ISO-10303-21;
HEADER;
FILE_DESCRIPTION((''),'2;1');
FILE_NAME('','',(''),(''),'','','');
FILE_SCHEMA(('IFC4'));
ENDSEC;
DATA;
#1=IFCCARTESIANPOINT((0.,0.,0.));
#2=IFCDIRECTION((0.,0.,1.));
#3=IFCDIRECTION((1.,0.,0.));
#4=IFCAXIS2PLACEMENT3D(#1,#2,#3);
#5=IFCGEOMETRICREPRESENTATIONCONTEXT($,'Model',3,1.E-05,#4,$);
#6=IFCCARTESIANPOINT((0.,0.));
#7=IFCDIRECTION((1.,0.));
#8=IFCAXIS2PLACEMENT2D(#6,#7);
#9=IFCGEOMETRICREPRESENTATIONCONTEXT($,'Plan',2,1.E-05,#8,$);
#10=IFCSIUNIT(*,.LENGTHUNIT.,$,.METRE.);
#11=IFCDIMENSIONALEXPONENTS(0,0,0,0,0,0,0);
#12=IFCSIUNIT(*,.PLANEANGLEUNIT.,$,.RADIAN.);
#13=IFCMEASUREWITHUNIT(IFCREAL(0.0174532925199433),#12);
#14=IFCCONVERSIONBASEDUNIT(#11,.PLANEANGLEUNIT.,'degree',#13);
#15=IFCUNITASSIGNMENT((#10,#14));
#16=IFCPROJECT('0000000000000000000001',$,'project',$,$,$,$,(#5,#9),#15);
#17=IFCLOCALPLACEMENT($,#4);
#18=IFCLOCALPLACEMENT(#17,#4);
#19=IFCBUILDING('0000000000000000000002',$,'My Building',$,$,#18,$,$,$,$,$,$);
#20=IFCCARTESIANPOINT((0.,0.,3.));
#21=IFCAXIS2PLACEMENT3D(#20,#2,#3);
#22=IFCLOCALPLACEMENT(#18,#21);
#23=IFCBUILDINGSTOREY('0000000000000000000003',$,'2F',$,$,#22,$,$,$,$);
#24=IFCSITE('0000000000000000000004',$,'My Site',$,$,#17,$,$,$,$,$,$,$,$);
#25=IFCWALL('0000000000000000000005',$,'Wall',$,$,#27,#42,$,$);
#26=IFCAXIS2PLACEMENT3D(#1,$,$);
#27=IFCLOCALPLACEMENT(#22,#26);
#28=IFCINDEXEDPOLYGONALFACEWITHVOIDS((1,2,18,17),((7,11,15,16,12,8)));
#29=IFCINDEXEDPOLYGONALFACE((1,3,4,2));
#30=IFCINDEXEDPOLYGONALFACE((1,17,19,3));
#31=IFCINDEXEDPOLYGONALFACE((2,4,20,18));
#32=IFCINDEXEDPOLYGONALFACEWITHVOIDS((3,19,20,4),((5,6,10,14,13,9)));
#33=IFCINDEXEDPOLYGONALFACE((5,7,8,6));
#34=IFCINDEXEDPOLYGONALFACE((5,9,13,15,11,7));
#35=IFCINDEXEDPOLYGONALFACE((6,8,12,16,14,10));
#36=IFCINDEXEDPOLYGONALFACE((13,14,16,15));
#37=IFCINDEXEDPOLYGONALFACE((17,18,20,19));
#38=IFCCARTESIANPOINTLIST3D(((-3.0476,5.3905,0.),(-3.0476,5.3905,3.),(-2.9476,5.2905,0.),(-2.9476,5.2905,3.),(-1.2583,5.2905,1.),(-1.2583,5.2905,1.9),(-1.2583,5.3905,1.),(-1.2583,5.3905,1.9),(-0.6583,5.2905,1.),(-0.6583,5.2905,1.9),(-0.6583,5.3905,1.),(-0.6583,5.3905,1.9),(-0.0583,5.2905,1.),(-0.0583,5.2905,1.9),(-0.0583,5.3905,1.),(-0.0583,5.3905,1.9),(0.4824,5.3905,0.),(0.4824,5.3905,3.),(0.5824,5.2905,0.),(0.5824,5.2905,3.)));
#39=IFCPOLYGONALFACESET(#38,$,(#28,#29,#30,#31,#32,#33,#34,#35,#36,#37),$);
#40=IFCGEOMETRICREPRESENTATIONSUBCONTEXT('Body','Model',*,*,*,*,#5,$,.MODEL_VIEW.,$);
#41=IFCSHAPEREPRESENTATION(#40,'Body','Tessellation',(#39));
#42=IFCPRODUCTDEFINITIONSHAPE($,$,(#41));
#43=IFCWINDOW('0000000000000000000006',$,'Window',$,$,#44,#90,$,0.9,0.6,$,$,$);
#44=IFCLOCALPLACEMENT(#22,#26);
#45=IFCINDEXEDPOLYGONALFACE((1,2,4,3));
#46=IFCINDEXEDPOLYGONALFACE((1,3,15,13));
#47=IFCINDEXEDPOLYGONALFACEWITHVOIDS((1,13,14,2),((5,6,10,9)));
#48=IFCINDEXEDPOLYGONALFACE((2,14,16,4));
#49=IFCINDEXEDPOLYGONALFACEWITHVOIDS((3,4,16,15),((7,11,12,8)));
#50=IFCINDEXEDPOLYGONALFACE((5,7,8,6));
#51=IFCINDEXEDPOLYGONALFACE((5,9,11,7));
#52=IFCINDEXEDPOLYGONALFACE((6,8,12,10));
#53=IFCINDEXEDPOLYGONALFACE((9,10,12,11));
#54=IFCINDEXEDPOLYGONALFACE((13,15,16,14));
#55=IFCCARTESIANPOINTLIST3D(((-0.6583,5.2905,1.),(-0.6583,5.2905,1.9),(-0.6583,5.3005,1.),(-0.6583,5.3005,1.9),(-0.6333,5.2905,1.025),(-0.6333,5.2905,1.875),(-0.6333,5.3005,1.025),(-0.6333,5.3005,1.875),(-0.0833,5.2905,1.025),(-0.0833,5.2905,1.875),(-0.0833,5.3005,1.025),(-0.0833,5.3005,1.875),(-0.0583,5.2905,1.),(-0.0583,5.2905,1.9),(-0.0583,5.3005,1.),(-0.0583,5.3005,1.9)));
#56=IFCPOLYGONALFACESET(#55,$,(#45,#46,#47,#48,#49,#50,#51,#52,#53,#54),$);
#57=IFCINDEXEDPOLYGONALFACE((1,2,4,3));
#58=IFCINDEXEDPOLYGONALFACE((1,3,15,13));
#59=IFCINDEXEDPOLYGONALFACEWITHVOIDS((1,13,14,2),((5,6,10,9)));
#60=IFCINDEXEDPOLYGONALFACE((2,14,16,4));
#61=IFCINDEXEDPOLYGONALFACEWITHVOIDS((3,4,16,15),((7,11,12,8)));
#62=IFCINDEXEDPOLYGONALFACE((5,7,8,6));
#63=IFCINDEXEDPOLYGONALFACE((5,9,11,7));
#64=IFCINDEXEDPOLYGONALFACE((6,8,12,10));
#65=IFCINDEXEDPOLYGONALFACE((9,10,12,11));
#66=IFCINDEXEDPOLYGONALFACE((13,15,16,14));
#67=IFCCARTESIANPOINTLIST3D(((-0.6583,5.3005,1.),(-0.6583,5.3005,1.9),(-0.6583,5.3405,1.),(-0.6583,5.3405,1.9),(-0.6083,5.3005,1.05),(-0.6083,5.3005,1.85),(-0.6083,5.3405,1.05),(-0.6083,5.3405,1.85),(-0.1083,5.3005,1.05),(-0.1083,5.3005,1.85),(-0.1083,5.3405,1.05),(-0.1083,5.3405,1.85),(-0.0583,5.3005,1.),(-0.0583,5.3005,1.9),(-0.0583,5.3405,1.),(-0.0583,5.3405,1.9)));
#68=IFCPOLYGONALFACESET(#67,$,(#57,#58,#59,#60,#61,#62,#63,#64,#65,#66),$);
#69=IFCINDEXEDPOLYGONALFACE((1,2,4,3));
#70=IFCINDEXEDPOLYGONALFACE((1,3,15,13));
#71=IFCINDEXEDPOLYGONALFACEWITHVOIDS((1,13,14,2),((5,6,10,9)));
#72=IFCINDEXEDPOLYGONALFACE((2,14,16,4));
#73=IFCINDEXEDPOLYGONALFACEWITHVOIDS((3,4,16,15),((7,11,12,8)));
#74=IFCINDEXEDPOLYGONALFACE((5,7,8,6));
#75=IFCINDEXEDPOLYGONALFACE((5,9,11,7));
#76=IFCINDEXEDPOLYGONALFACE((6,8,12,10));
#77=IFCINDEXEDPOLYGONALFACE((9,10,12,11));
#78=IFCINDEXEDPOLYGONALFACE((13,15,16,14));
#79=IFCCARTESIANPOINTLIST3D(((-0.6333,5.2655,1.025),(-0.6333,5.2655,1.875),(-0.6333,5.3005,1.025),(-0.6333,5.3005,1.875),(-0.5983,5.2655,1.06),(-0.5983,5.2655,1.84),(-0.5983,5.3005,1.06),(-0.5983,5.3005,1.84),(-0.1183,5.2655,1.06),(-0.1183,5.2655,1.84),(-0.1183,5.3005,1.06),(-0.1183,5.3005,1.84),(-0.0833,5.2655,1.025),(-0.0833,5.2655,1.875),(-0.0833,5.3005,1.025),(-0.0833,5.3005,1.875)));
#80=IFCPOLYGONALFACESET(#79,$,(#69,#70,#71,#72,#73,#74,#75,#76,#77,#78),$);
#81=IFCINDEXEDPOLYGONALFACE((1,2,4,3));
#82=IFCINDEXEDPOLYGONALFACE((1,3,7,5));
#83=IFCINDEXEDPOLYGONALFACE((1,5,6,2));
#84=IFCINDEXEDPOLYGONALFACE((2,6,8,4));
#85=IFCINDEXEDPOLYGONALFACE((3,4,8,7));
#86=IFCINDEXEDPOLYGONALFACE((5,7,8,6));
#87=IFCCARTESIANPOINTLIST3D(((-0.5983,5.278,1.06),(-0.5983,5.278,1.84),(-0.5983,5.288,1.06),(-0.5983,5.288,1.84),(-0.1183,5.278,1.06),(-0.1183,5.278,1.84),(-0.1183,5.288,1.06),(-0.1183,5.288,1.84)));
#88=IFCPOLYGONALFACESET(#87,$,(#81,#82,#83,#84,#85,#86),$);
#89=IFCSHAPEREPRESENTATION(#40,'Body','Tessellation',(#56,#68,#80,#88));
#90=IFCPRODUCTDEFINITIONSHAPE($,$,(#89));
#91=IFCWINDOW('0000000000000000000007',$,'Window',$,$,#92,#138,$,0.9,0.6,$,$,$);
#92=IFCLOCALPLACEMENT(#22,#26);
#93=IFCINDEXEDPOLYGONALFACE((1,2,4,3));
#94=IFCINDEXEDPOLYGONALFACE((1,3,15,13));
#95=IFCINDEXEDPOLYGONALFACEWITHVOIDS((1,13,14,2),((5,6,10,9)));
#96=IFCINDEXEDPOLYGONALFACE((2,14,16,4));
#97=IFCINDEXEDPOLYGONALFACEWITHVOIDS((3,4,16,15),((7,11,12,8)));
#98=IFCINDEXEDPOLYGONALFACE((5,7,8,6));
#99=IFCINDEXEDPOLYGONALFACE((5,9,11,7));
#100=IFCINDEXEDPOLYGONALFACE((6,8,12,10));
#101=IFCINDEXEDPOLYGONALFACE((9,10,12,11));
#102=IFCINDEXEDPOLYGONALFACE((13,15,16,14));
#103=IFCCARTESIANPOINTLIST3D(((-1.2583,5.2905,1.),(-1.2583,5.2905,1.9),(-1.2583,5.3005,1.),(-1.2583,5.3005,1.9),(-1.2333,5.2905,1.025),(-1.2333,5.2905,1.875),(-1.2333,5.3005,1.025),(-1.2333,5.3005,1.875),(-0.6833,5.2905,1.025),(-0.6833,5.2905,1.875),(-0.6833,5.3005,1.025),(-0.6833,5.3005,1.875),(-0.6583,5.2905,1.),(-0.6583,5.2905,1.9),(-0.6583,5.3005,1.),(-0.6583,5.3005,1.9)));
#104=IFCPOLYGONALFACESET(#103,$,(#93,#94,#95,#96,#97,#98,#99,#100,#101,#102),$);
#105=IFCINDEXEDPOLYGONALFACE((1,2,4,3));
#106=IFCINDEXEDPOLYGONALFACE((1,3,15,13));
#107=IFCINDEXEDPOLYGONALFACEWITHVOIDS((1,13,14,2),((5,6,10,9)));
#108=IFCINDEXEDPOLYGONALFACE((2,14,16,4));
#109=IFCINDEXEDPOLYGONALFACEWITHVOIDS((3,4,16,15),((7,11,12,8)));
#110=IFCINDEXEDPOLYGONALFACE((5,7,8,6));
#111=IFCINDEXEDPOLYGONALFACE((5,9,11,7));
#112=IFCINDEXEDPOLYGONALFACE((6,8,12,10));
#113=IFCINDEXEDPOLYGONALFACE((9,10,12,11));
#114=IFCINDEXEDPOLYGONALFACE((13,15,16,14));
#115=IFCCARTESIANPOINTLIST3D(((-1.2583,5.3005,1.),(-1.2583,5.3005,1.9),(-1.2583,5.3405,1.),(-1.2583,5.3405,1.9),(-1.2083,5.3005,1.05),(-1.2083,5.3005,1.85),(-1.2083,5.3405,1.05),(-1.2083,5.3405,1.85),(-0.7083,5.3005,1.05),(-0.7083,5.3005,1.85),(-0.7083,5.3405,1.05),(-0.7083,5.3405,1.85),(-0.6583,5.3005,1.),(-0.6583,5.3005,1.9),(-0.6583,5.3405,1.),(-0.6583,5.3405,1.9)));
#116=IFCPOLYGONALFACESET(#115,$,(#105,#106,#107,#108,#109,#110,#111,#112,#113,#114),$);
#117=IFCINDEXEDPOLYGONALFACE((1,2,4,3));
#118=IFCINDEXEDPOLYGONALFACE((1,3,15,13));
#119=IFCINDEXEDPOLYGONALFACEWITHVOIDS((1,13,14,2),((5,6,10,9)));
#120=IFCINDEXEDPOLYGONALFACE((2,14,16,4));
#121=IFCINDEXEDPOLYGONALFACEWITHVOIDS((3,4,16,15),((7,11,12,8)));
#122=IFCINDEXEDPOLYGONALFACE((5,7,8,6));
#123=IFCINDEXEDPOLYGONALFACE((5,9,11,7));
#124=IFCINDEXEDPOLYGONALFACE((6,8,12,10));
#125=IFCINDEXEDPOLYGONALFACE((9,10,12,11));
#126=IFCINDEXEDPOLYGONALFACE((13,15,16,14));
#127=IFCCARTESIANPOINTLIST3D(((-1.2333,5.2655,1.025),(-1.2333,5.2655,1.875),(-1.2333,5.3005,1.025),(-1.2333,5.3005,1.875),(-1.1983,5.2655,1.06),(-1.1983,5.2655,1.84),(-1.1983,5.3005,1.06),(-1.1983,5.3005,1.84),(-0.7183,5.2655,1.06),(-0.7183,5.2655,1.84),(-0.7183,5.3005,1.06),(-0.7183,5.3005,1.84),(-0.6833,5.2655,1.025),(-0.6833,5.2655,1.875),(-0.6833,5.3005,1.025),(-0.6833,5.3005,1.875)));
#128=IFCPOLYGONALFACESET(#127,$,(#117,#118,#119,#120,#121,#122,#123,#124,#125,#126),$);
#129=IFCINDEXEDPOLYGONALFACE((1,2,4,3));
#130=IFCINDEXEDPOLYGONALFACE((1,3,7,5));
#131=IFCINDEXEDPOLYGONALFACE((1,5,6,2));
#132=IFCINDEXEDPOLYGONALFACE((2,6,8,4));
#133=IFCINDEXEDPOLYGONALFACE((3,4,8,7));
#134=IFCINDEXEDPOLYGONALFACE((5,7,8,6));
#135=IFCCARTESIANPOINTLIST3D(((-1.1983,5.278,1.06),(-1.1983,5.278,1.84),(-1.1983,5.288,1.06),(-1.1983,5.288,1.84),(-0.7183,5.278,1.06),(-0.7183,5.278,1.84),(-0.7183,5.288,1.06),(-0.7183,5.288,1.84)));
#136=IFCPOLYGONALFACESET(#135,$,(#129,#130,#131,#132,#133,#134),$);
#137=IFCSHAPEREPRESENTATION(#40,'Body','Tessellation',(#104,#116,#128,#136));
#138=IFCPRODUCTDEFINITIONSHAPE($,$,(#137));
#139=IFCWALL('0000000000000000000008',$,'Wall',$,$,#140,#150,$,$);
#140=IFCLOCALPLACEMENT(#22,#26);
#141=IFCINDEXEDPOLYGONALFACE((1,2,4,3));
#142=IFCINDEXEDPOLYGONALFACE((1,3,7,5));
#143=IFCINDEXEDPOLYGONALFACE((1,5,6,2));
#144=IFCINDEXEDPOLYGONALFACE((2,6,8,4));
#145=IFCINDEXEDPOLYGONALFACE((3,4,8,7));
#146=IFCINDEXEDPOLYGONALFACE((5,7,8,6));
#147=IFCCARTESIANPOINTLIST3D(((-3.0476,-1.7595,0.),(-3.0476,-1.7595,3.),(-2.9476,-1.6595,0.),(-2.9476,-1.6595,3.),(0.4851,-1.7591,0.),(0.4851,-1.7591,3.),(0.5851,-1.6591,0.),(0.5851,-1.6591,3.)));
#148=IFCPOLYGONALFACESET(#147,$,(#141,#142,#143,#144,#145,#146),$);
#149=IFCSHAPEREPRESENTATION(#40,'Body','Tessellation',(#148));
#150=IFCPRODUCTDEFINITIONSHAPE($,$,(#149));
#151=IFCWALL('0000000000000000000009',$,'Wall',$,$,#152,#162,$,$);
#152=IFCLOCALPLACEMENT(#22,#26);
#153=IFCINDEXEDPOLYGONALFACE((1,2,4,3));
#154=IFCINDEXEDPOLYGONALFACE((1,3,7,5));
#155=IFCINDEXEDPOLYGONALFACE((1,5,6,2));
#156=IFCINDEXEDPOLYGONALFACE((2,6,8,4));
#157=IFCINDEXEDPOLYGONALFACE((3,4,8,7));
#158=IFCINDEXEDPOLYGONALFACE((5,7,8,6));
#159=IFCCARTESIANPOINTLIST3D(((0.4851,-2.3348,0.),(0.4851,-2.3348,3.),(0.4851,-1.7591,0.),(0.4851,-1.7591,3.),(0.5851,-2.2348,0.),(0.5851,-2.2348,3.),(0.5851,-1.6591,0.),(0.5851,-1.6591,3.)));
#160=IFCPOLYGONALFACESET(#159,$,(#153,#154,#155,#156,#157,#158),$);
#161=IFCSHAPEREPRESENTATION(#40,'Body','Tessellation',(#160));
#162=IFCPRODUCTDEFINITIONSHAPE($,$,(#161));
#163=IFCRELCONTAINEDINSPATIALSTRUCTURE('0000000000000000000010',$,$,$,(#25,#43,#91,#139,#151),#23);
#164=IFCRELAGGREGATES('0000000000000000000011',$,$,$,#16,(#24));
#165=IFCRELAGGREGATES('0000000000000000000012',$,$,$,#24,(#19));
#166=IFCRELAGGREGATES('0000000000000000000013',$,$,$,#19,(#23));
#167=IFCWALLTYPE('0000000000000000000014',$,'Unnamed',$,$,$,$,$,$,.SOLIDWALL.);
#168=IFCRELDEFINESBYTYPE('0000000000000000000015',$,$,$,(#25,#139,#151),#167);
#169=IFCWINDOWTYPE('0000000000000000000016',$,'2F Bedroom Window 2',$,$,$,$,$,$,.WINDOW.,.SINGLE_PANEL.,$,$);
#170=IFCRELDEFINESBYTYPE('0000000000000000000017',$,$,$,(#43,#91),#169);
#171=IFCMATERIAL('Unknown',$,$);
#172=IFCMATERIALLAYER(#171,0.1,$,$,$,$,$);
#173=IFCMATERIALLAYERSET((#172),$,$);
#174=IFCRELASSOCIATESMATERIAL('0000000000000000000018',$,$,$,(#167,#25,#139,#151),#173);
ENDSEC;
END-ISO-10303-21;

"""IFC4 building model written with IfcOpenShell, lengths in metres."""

from ifc_helpers import new_model, entity, si_unit, converted_unit, frame, origin_with_axes, origin_2d_with_axis, place, context, subcontext, project, spatial, line, indexed_curve, outline, extrude, shape, source, transform, mapped, material, layer, layer_set, layer_usage, type_object, type_shapes, element, fill, save


model = new_model("IFC4")

# Units and contexts
model_context = context("Model", 3, precision=1e-05, world=origin_with_axes())
plan_context = context("Plan", 2, precision=1e-05, world=origin_2d_with_axis())
body_context_1 = subcontext(model_context, "Body", "Model", "MODEL_VIEW")
body_context_2 = subcontext(plan_context, "Body", "Plan", "PLAN_VIEW")
ifc_project = project(units=[si_unit("LENGTHUNIT", "METRE"), converted_unit("PLANEANGLEUNIT", "degree", entity("IfcReal", 0.0174532925199433), si_unit("PLANEANGLEUNIT", "RADIAN"), dimensions=[0, 0, 0, 0, 0, 0, 0])], contexts=[model_context, plan_context])

# Site, building, storey
site_placement = place(None, origin_with_axes())
site = spatial("IfcSite", under=ifc_project, at=site_placement, Name="My Site")
building_placement = place(site_placement, origin_with_axes())
building = spatial("IfcBuilding", under=site, at=building_placement, Name="My Building")
storey_placement = place(building_placement, frame((0.0, 0.0, 3.0), z_axis=(0.0, 0.0, 1.0), x_axis=(1.0, 0.0, 0.0)))
storey = spatial("IfcBuildingStorey", under=building, at=storey_placement, Name="2F")

# Shared definitions
ifc_material = material(Name="Unknown")

# Shared definitions
ifc_layer_1 = layer(ifc_material, 0.1)
ifc_layer_set_1 = layer_set([ifc_layer_1])
wall_type = type_object("IfcWallType", Name="Unnamed", PredefinedType="SOLIDWALL", material=ifc_layer_set_1)

# Wall, openings, windows
ifc_layer_usage_1 = layer_usage(ifc_layer_set_1, "AXIS2", "POSITIVE", 0.0)
wall_1_placement = place(storey_placement, frame((0.4824, 5.3905, 0.0), z_axis=(0.0, 0.0, 1.0), x_axis=(-1.0, 0.0, 0.0)))
wall_1 = element("IfcWall", 1, at=wall_1_placement, inside=storey, type_object=wall_type, material=ifc_layer_usage_1, Name="Wall", context=body_context_1, shape_type="SweptSolid", body=[
    extrude(outline(indexed_curve([(0.0, 0.0), (-0.1, 0.1), (3.43, 0.1), (3.53, 0.0)], segments=[line(1, 2, 3, 4, 1)])), origin_with_axes(), (0.0, 0.0, 1.0), 3.0),
])
shared_shape_1 = source(origin_with_axes(), body_context_1, "Body", "SweptSolid", [
    extrude(outline(indexed_curve([(0.0, 0.0), (0.6, 0.0), (0.6, 0.9), (0.0, 0.9)], segments=[line(1, 2, 3, 4, 1)])), frame((0.0, -0.6, 0.0), z_axis=(0.0, -1.0, 0.0), x_axis=(1.0, 0.0, 0.0)), (0.0, 0.0, -1.0), 1.2),
])
opening_1_placement = place(wall_1_placement, frame((0.5406, 0.0, 1.0), z_axis=(0.0, 0.0, 1.0), x_axis=(1.0, 0.0, 0.0)))
opening_1 = element("IfcOpeningElement", 2, at=opening_1_placement, cuts=wall_1, PredefinedType="OPENING", context=body_context_1, shape_type="MappedRepresentation", body=[
    mapped(shared_shape_1, transform((0.0, 0.0, 0.0), x_axis=(1.0, 0.0, 0.0), y_axis=(0.0, 1.0, 0.0), z_axis=(0.0, 0.0, 1.0), scale=1.0)),
])
opening_2_placement = place(wall_1_placement, frame((1.1406, 0.0, 1.0), z_axis=(0.0, 0.0, 1.0), x_axis=(1.0, 0.0, 0.0)))
opening_2 = element("IfcOpeningElement", 3, at=opening_2_placement, cuts=wall_1, PredefinedType="OPENING", context=body_context_1, shape_type="MappedRepresentation", body=[
    mapped(shared_shape_1, transform((0.0, 0.0, 0.0), x_axis=(1.0, 0.0, 0.0), y_axis=(0.0, 1.0, 0.0), z_axis=(0.0, 0.0, 1.0), scale=1.0)),
])
window_type_1 = type_object("IfcWindowType", Name="2F Bedroom Window 2", PartitioningType="SINGLE_PANEL", PredefinedType="WINDOW")
shared_shape_2 = source(origin_with_axes(), body_context_1, "Body", "SweptSolid", [
    extrude(outline(indexed_curve([(0.0, 0.0), (0.6, 0.0), (0.6, 0.9), (0.0, 0.9)], segments=[line(1, 2, 3, 4, 1)]), holes=[indexed_curve([(0.025, 0.025), (0.575, 0.025), (0.575, 0.875), (0.025, 0.875)], segments=[line(1, 2, 3, 4, 1)])]), frame((0.0, 0.09, 0.0), z_axis=(0.0, -1.0, 0.0), x_axis=(1.0, 0.0, 0.0)), (0.0, 0.0, -1.0), 0.01),
    extrude(outline(indexed_curve([(0.0, 0.0), (0.6, 0.0), (0.6, 0.9), (0.0, 0.9)], segments=[line(1, 2, 3, 4, 1)]), holes=[indexed_curve([(0.05, 0.05), (0.55, 0.05), (0.55, 0.85), (0.05, 0.85)], segments=[line(1, 2, 3, 4, 1)])]), frame((0.0, 0.05, 0.0), z_axis=(0.0, -1.0, 0.0), x_axis=(1.0, 0.0, 0.0)), (0.0, 0.0, -1.0), 0.04),
    extrude(outline(indexed_curve([(0.0, 0.0), (0.55, 0.0), (0.55, 0.85), (0.0, 0.85)], segments=[line(1, 2, 3, 4, 1)]), holes=[indexed_curve([(0.035, 0.035), (0.515, 0.035), (0.515, 0.815), (0.035, 0.815)], segments=[line(1, 2, 3, 4, 1)])]), frame((0.025, 0.09, 0.025), z_axis=(0.0, -1.0, 0.0), x_axis=(1.0, 0.0, 0.0)), (0.0, 0.0, -1.0), 0.035),
    extrude(outline(indexed_curve([(0.035, 0.035), (0.515, 0.035), (0.515, 0.815), (0.035, 0.815)], segments=[line(1, 2, 3, 4, 1)])), frame((0.025, 0.1025, 0.025), z_axis=(0.0, -1.0, 0.0), x_axis=(1.0, 0.0, 0.0)), (0.0, 0.0, -1.0), 0.01),
])
shared_shape_3 = source(origin_with_axes(), body_context_2, "Body", "Curve2D", [
    entity("IfcIndexedPolyCurve", entity("IfcCartesianPointList2D", [[0.05, 0.05], [0.55, 0.05]])),
    entity("IfcIndexedPolyCurve", entity("IfcCartesianPointList2D", [[0.0, 0.1], [0.025, 0.1], [0.025, 0.09], [0.05, 0.09], [0.05, 0.05], [0.0, 0.05]]), [entity("IfcLineIndex", [1, 2, 3, 4, 5, 6, 1])]),
    entity("IfcIndexedPolyCurve", entity("IfcCartesianPointList2D", [[0.6, 0.1], [0.575, 0.1], [0.575, 0.09], [0.55, 0.09], [0.55, 0.05], [0.6, 0.05]]), [entity("IfcLineIndex", [1, 2, 3, 4, 5, 6, 1])]),
    entity("IfcIndexedPolyCurve", entity("IfcCartesianPointList2D", [[0.025, 0.09], [0.06, 0.09], [0.06, 0.125], [0.025, 0.125]]), [entity("IfcLineIndex", [1, 2, 3, 4, 1])]),
    entity("IfcIndexedPolyCurve", entity("IfcCartesianPointList2D", [[0.575, 0.09], [0.54, 0.09], [0.54, 0.125], [0.575, 0.125]]), [entity("IfcLineIndex", [1, 2, 3, 4, 1])]),
    entity("IfcIndexedPolyCurve", entity("IfcCartesianPointList2D", [[0.06, 0.09], [0.54, 0.09]])),
    entity("IfcIndexedPolyCurve", entity("IfcCartesianPointList2D", [[0.06, 0.125], [0.54, 0.125]])),
    entity("IfcIndexedPolyCurve", entity("IfcCartesianPointList2D", [[0.06, 0.1075], [0.54, 0.1075]])),
])
type_shapes(window_type_1, [shared_shape_2, shared_shape_3])
window_1_placement = place(opening_1_placement, frame((0.0, 0.0, 0.0), z_axis=(0.0, 0.0, 1.0), x_axis=(1.0, 0.0, 0.0)))
window_1 = element("IfcWindow", 4, at=window_1_placement, inside=storey, type_object=window_type_1, Name="Window", OverallHeight=0.9, OverallWidth=0.6, shapes=[
    shape(body_context_1, "Body", "MappedRepresentation", [mapped(shared_shape_2, transform((0.0, 0.0, 0.0), x_axis=(1.0, 0.0, 0.0), y_axis=(0.0, 1.0, 0.0), z_axis=(0.0, 0.0, 1.0), scale=1.0))]),
    shape(body_context_2, "Body", "MappedRepresentation", [mapped(shared_shape_3, transform((0.0, 0.0, 0.0), x_axis=(1.0, 0.0, 0.0), y_axis=(0.0, 1.0, 0.0), z_axis=(0.0, 0.0, 1.0), scale=1.0))]),
])
fill(opening_1, window_1)
window_2_placement = place(opening_2_placement, frame((0.0, 0.0, 0.0), z_axis=(0.0, 0.0, 1.0), x_axis=(1.0, 0.0, 0.0)))
window_2 = element("IfcWindow", 5, at=window_2_placement, inside=storey, type_object=window_type_1, Name="Window", OverallHeight=0.9, OverallWidth=0.6, shapes=[
    shape(body_context_1, "Body", "MappedRepresentation", [mapped(shared_shape_2, transform((0.0, 0.0, 0.0), x_axis=(1.0, 0.0, 0.0), y_axis=(0.0, 1.0, 0.0), z_axis=(0.0, 0.0, 1.0), scale=1.0))]),
    shape(body_context_2, "Body", "MappedRepresentation", [mapped(shared_shape_3, transform((0.0, 0.0, 0.0), x_axis=(1.0, 0.0, 0.0), y_axis=(0.0, 1.0, 0.0), z_axis=(0.0, 0.0, 1.0), scale=1.0))]),
])
fill(opening_2, window_2)

# Walls
ifc_layer_usage_2 = layer_usage(ifc_layer_set_1, "AXIS2", "POSITIVE", 0.0)
wall_2_placement = place(storey_placement, frame((-3.0476, -1.7595, 0.0), z_axis=(0.0, 0.0, 1.0), x_axis=(1.0, 0.000125, 0.0)))
element("IfcWall", 6, at=wall_2_placement, inside=storey, type_object=wall_type, material=ifc_layer_usage_2, Name="Wall", context=body_context_1, shape_type="SweptSolid", body=[
    extrude(outline(indexed_curve([(0.0, 0.0), (0.1, 0.1), (3.6327, 0.1), (3.5327, 0.0)], segments=[line(1, 2, 3, 4, 1)])), origin_with_axes(), (0.0, 0.0, 1.0), 3.0),
])
ifc_layer_usage_3 = layer_usage(ifc_layer_set_1, "AXIS2", "POSITIVE", 0.0)
wall_3_placement = place(storey_placement, frame((0.4851, -1.7591, 0.0), z_axis=(0.0, 0.0, 1.0), x_axis=(0.0, -1.0, 0.0)))
element("IfcWall", 7, at=wall_3_placement, inside=storey, type_object=wall_type, material=ifc_layer_usage_3, Name="Wall", context=body_context_1, shape_type="SweptSolid", body=[
    extrude(outline(indexed_curve([(0.0, 0.0), (-0.1, 0.1), (0.4757, 0.1), (0.5757, 0.0)], segments=[line(1, 2, 3, 4, 1)])), origin_with_axes(), (0.0, 0.0, 1.0), 3.0),
])

save(model, "model.ifc")
